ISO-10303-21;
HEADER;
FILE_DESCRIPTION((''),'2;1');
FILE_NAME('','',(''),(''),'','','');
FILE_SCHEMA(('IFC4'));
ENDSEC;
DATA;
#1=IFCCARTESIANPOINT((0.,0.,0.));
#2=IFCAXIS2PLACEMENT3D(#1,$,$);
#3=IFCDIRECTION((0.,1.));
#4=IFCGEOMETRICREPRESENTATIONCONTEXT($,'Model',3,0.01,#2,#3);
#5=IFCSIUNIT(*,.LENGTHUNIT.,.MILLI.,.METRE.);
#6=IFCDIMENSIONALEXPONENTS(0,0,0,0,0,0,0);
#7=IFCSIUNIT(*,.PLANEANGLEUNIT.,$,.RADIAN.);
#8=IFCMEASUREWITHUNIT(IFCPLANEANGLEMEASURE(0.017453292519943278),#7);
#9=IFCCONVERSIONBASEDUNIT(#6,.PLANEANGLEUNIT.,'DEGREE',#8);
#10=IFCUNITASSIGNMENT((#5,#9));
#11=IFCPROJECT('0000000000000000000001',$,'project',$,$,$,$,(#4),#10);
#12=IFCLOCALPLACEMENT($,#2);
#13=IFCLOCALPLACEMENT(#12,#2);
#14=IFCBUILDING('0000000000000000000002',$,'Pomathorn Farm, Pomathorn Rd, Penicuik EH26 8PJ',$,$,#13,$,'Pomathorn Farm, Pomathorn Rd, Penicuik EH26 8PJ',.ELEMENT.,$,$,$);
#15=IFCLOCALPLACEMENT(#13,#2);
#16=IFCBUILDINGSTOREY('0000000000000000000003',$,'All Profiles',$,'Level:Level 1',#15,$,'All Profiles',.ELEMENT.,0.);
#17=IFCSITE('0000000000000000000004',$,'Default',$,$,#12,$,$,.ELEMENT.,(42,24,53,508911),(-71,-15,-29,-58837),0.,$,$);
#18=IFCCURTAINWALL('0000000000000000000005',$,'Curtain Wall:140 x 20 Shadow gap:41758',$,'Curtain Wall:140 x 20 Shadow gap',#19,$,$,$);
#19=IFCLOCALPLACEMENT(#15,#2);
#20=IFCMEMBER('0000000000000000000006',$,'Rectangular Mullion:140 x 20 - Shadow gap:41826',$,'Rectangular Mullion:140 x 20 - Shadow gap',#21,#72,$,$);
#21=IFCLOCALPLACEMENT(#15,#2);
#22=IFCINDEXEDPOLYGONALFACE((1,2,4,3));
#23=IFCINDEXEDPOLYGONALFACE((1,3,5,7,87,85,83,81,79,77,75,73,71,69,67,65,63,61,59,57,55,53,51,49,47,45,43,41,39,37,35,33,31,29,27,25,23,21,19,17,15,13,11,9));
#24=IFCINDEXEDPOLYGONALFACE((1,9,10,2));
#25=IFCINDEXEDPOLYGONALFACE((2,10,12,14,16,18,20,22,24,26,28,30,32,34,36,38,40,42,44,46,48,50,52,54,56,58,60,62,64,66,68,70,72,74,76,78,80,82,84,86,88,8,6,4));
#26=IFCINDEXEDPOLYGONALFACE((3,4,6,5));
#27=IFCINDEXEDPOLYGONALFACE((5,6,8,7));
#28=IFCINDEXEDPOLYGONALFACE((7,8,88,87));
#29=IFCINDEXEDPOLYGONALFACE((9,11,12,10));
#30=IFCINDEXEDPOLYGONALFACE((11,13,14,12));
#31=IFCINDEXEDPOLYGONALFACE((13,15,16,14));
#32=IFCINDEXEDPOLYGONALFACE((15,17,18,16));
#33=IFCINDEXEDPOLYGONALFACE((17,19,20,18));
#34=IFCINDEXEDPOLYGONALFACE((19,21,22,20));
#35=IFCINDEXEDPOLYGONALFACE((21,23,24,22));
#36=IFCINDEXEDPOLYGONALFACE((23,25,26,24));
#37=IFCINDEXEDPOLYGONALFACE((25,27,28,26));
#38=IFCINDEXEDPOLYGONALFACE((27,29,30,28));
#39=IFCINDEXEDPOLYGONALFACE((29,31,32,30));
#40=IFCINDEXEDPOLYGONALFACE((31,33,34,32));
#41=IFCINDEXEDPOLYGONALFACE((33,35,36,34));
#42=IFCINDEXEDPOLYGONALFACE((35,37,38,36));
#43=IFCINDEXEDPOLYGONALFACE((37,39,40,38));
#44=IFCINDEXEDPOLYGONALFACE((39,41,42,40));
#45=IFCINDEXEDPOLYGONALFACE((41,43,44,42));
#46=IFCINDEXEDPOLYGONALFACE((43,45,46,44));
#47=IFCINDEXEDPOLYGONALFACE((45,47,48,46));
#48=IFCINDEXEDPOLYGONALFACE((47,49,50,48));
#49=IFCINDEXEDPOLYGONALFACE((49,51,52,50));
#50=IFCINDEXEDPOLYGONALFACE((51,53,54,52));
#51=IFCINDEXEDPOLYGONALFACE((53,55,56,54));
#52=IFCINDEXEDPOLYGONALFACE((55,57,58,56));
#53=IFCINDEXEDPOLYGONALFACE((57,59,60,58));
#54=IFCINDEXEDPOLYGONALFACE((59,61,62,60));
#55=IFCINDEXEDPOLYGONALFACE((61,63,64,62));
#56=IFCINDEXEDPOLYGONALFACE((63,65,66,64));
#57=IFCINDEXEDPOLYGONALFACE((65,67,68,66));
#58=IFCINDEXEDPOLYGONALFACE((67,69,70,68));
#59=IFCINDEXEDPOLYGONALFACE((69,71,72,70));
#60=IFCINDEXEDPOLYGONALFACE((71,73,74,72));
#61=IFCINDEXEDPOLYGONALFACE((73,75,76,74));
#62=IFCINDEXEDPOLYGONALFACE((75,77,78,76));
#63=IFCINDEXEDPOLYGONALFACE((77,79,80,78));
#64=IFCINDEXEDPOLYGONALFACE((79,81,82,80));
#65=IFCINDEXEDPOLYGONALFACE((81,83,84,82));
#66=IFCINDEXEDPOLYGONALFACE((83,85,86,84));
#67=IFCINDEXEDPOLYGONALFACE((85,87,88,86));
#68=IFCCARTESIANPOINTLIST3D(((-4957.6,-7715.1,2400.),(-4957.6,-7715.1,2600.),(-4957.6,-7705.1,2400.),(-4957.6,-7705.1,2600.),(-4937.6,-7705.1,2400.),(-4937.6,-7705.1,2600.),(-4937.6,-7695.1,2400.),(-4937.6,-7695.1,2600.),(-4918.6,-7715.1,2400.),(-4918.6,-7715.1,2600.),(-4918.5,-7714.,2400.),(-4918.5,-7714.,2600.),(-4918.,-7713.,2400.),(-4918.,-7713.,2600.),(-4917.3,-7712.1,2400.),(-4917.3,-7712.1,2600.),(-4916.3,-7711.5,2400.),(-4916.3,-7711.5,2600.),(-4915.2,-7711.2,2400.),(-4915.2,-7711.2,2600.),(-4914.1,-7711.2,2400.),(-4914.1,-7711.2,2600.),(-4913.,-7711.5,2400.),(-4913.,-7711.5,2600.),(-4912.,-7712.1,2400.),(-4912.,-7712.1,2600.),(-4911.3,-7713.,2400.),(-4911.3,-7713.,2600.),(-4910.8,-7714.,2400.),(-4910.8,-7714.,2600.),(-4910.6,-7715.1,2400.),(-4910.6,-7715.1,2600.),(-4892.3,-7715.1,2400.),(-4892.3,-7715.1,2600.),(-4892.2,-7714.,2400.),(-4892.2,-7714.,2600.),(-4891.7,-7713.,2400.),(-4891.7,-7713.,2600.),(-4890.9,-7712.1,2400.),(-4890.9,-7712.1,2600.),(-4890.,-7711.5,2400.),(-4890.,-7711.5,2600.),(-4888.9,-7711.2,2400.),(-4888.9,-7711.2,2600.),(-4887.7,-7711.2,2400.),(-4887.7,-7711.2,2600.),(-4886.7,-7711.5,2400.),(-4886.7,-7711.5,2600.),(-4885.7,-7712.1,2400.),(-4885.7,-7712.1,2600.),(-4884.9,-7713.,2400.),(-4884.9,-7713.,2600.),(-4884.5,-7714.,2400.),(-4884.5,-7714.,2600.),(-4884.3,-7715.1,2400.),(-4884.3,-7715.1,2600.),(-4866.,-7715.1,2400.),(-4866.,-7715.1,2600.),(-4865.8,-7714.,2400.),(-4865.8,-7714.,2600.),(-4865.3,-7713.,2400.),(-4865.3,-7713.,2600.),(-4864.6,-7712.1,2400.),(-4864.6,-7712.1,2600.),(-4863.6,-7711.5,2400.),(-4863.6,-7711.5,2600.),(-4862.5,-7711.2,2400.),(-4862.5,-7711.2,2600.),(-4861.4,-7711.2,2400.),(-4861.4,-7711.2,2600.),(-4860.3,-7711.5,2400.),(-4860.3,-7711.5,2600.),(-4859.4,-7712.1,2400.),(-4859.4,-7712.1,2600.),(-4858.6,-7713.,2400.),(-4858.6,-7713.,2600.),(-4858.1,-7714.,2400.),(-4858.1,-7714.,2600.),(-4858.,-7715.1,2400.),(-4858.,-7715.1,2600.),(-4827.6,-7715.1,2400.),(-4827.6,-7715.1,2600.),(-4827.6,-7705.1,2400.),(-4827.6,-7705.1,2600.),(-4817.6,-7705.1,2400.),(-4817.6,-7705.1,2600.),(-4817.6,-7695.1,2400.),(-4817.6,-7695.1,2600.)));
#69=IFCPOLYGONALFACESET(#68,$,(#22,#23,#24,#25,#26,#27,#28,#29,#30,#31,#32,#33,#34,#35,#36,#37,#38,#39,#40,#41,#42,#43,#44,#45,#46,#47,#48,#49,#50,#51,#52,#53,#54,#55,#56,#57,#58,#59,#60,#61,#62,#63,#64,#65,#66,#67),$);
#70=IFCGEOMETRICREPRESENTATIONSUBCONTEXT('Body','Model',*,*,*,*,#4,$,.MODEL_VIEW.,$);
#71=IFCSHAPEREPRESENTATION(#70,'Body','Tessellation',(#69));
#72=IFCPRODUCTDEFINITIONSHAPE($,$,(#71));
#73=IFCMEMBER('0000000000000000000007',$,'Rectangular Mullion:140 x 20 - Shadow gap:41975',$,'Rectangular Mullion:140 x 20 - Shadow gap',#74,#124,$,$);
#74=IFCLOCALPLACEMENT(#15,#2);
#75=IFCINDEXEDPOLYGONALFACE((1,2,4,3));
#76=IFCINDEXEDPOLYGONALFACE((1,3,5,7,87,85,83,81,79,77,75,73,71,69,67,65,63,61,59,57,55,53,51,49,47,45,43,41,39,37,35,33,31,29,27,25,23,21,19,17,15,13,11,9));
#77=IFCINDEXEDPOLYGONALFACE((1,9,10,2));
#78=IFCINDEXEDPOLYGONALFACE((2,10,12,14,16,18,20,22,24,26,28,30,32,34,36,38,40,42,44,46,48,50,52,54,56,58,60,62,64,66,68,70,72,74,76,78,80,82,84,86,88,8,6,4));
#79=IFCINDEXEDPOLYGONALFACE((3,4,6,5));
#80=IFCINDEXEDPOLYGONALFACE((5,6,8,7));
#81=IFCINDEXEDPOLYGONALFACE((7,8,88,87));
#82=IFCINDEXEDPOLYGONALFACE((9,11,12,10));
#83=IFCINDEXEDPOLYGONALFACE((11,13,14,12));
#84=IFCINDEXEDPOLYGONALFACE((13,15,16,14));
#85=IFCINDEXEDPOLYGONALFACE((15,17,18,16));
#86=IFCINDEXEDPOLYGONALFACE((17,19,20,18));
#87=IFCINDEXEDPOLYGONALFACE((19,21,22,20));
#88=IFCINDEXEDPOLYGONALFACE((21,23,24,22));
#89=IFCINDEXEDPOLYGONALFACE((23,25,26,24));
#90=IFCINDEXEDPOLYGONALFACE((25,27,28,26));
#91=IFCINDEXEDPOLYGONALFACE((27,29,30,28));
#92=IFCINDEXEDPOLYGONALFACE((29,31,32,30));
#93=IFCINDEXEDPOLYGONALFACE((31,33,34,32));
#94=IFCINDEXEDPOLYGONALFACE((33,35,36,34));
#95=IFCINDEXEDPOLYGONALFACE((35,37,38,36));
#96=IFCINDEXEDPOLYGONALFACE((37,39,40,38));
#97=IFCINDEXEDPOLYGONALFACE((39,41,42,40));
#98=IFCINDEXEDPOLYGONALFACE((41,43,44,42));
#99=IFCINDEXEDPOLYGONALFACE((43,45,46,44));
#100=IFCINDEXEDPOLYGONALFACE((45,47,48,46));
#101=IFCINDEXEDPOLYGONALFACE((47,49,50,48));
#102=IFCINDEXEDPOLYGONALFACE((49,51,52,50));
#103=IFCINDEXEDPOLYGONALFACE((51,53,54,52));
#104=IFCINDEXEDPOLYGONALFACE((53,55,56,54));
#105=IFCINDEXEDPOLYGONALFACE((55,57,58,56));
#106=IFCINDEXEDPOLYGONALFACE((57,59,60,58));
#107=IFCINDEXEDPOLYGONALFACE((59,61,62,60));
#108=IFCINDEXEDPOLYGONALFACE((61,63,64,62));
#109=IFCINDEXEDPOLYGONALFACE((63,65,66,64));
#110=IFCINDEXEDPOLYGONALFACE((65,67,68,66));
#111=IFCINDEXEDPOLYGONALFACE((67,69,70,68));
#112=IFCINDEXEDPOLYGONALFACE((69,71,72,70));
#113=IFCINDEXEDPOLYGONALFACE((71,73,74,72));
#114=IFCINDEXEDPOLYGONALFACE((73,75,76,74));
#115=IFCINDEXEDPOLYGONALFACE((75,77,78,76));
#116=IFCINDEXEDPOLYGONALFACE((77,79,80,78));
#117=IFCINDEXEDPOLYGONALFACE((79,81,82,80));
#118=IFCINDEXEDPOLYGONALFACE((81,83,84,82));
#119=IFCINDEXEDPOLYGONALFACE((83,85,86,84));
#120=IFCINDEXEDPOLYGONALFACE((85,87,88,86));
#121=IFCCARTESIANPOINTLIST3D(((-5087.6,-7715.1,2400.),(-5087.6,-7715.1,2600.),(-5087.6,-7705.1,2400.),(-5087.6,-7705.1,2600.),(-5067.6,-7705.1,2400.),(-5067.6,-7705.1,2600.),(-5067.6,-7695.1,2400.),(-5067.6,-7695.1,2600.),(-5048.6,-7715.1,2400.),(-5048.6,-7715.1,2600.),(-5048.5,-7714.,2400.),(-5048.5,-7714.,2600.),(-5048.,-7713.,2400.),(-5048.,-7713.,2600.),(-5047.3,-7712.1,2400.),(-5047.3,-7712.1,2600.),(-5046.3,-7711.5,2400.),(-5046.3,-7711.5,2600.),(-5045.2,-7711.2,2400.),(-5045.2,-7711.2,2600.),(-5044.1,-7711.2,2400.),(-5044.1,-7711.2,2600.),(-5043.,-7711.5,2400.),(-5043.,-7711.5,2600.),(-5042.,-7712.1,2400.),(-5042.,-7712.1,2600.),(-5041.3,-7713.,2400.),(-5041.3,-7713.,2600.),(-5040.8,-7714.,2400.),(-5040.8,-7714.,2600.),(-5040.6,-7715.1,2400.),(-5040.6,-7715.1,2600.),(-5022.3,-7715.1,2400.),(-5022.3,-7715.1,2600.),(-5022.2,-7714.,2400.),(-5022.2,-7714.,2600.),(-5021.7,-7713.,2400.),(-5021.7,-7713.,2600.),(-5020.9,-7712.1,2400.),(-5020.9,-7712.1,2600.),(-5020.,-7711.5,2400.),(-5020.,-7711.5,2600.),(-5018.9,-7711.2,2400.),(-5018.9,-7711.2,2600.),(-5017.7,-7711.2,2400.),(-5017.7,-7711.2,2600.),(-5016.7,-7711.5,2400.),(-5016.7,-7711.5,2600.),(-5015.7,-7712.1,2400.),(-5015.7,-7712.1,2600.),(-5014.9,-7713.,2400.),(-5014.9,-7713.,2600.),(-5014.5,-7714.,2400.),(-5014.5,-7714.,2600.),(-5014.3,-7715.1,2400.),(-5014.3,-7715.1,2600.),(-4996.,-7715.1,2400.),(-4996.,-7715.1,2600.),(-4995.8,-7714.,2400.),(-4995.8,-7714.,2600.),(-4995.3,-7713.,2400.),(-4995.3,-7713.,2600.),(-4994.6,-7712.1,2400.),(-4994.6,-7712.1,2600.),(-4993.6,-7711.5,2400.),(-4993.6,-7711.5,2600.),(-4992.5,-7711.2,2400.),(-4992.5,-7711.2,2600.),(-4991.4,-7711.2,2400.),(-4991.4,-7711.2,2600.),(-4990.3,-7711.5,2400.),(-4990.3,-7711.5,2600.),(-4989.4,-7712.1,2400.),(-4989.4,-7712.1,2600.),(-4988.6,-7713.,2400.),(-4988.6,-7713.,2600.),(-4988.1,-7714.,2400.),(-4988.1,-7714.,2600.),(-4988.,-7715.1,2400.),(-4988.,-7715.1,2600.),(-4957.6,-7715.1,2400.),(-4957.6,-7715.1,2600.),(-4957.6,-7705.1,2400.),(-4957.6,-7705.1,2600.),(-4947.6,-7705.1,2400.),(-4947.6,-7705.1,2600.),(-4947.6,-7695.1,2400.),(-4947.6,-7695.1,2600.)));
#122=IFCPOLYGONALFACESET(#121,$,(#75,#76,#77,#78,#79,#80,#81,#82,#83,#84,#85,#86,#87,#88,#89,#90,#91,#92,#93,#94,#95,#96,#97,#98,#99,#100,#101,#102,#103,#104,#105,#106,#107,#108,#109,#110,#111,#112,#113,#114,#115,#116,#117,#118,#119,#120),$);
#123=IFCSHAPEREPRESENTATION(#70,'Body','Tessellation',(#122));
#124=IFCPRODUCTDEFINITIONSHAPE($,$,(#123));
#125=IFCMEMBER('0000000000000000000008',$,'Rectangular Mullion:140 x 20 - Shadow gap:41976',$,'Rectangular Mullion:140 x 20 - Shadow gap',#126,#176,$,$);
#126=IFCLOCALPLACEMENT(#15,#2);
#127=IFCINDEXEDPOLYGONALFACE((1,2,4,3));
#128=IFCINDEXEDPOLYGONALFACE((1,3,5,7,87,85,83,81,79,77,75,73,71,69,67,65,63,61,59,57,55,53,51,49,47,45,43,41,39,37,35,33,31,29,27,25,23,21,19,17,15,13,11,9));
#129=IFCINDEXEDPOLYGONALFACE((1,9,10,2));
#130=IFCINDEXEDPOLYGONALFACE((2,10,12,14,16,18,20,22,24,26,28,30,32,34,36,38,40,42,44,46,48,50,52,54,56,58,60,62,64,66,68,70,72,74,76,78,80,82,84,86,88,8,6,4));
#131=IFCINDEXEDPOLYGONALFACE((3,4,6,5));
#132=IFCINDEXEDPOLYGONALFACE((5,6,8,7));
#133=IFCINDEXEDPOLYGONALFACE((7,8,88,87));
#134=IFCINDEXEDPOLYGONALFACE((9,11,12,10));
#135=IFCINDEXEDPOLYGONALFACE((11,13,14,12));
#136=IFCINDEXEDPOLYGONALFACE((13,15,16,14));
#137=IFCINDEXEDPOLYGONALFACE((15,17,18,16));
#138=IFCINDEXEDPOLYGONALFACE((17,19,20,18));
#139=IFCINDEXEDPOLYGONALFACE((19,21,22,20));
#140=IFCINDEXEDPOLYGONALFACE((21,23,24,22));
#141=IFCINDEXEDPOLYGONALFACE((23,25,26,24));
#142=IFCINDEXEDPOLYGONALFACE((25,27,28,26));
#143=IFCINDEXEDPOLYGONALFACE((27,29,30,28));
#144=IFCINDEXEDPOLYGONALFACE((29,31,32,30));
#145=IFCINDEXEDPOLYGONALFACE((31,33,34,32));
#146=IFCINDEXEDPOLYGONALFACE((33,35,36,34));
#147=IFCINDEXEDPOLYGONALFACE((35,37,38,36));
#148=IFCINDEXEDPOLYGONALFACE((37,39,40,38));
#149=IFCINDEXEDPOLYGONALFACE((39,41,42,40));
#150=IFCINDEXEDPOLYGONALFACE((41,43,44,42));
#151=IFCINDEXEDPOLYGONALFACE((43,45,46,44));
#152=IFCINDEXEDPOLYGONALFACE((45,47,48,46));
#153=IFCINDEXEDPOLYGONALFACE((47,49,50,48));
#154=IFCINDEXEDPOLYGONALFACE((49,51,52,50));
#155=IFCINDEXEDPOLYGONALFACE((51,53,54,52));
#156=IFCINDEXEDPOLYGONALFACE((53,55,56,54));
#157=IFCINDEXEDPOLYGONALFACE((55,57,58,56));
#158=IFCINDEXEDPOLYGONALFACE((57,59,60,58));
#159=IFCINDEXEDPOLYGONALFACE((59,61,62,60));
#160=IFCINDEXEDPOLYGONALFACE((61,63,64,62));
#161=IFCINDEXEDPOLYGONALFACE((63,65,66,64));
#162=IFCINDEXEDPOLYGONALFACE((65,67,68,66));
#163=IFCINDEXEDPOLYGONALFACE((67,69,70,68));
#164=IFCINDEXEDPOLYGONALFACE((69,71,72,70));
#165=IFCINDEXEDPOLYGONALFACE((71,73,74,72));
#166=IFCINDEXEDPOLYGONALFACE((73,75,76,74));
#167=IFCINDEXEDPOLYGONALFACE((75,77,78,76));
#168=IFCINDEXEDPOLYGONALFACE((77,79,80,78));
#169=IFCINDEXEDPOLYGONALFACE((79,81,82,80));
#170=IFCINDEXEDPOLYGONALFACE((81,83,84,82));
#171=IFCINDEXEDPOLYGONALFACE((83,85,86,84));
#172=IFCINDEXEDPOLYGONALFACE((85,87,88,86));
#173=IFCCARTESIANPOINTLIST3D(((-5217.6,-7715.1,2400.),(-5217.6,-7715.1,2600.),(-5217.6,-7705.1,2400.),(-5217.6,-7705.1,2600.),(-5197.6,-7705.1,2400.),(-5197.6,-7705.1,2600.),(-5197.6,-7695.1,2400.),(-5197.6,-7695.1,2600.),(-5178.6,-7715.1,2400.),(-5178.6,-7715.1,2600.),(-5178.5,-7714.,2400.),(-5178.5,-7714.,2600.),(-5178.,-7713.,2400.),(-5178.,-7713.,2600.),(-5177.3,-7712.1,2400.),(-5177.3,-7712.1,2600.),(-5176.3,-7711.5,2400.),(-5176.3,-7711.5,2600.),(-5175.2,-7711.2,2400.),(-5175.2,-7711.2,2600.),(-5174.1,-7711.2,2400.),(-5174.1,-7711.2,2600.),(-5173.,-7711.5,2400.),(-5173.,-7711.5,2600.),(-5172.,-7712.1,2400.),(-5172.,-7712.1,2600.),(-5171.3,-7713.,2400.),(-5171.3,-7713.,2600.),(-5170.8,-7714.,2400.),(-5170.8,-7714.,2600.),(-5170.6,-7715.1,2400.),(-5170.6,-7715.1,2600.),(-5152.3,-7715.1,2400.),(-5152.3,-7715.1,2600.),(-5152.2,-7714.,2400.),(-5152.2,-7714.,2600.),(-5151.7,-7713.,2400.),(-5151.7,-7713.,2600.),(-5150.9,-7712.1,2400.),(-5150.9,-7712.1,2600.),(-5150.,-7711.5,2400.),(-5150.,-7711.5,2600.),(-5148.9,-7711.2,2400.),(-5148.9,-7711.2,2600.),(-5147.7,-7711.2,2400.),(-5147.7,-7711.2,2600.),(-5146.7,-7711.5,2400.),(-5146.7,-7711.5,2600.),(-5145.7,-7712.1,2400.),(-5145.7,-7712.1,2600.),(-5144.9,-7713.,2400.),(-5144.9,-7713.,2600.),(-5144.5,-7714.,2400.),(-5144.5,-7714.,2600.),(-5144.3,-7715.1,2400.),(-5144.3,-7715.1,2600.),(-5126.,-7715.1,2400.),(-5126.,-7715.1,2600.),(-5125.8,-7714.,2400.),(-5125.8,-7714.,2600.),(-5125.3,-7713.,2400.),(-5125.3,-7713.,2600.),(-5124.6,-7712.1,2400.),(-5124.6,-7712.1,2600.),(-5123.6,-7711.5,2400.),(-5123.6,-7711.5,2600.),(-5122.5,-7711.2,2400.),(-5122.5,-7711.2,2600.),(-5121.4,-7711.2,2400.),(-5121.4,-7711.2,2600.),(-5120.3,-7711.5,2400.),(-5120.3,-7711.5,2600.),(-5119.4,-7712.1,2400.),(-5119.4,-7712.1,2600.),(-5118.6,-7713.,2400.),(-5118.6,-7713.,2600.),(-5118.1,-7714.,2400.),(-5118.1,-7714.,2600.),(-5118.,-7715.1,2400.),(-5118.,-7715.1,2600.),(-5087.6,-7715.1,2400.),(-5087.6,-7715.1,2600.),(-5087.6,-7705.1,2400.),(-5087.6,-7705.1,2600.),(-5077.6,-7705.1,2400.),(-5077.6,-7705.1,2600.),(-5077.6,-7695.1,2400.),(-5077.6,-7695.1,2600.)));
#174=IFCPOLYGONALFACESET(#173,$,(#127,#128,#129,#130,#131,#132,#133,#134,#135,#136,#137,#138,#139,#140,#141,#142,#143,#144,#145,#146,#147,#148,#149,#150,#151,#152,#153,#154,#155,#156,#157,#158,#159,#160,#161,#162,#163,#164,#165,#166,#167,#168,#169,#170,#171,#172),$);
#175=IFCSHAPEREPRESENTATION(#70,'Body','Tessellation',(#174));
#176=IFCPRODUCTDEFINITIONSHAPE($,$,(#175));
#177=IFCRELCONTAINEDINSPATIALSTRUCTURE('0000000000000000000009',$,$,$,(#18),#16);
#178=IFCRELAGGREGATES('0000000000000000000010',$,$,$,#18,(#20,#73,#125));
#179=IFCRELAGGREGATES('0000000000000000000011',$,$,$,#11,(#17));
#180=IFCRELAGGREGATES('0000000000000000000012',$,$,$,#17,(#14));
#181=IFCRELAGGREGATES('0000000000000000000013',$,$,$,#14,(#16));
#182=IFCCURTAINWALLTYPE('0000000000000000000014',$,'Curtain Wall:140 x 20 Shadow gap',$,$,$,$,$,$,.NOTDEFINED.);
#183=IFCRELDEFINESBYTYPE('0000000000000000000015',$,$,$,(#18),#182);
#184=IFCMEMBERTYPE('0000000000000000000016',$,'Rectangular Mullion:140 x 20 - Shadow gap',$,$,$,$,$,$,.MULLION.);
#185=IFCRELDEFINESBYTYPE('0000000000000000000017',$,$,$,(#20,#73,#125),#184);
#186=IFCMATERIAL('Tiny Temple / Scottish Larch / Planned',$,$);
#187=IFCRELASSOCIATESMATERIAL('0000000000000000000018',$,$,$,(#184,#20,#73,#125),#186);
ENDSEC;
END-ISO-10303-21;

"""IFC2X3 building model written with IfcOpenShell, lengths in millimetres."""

from ifc_helpers import new_model, entity, si_unit, converted_unit, direction, frame, frame_2d, origin, place, context, subcontext, project, spatial, polyline, circle_curve, parameter, trimmed, segment, composite_curve, outline, extrude, source, transform, mapped, material, type_object, type_shapes, element, aggregate, save


model = new_model("IFC2X3")

# Units and contexts
model_context = context("Model", 3, precision=0.01, world=origin(), true_north=direction((0.0, 1.0)))
body_context = subcontext(model_context, "Body", "Model", "MODEL_VIEW")
ifc_project = project(units=[si_unit("LENGTHUNIT", "METRE", prefix="MILLI"), converted_unit("PLANEANGLEUNIT", "DEGREE", entity("IfcPlaneAngleMeasure", 0.017453292519943278), si_unit("PLANEANGLEUNIT", "RADIAN"), dimensions=[0, 0, 0, 0, 0, 0, 0])], contexts=[model_context])

# Site, building, storey
site_placement = place(None, origin())
site = spatial("IfcSite", under=ifc_project, at=site_placement, Name="Default", CompositionType="ELEMENT", RefLatitude=(42, 24, 53, 508911), RefLongitude=(-71, -15, -29, -58837), RefElevation=0.0)
building_placement = place(site_placement, origin())
building = spatial("IfcBuilding", under=site, at=building_placement, Name="Pomathorn Farm, Pomathorn Rd, Penicuik EH26 8PJ", LongName="Pomathorn Farm, Pomathorn Rd, Penicuik EH26 8PJ", CompositionType="ELEMENT")
storey_placement = place(building_placement, origin())
storey = spatial("IfcBuildingStorey", under=building, at=storey_placement, Name="All Profiles", ObjectType="Level:Level 1", LongName="All Profiles", CompositionType="ELEMENT", Elevation=0.0)

# Curtain wall, members
ifc_material = material(Name="Tiny Temple / Scottish Larch / Planned")
curtain_wall_type_1 = type_object("IfcCurtainWallType", Name="Curtain Wall:140 x 20 Shadow gap", PredefinedType="NOTDEFINED")
curtain_wall_1_placement = place(storey_placement, origin())
curtain_wall_1 = element("IfcCurtainWall", 1, at=curtain_wall_1_placement, inside=storey, type_object=curtain_wall_type_1, Name="Curtain Wall:140 x 20 Shadow gap:41758", ObjectType="Curtain Wall:140 x 20 Shadow gap")
member_type_1 = type_object("IfcMemberType", Name="Rectangular Mullion:140 x 20 - Shadow gap", PredefinedType="MULLION", material=ifc_material)
shared_shape_1 = source(origin(), body_context, "Body", "SweptSolid", [
    extrude(outline(composite_curve([segment(polyline([(28.5, -5.7), (58.9, -5.7)]), True, "CONTINUOUS"), segment(polyline([(58.9, -5.7), (58.9, 4.3)]), True, "CONTINUOUS"), segment(polyline([(58.9, 4.3), (68.9, 4.3)]), True, "CONTINUOUS"), segment(polyline([(68.9, 4.3), (68.9, 14.3)]), True, "CONTINUOUS"), segment(polyline([(68.9, 14.3), (-51.1, 14.3)]), True, "CONTINUOUS"), segment(polyline([(-51.1, 14.3), (-51.1, 4.3)]), True, "CONTINUOUS"), segment(polyline([(-51.1, 4.3), (-71.1, 4.3)]), True, "CONTINUOUS"), segment(polyline([(-71.1, 4.3), (-71.1, -5.7)]), True, "CONTINUOUS"), segment(polyline([(-71.1, -5.7), (-32.1, -5.7)]), True, "CONTINUOUS"), segment(trimmed(circle_curve(frame_2d((-28.1, -5.7), x_axis=(1.0, 0.0)), 4.0), [parameter(360.0)], [parameter(180.0)], True, "PARAMETER"), False, "CONTINUOUS"), segment(polyline([(-24.1, -5.7), (-5.8, -5.7)]), True, "CONTINUOUS"), segment(trimmed(circle_curve(frame_2d((-1.8, -5.7), x_axis=(1.0, 0.0)), 4.0), [parameter(360.0)], [parameter(180.0)], True, "PARAMETER"), False, "CONTINUOUS"), segment(polyline([(2.2, -5.7), (20.5, -5.7)]), True, "CONTINUOUS"), segment(trimmed(circle_curve(frame_2d((24.5, -5.7), x_axis=(1.0, 0.0)), 4.0), [parameter(360.0)], [parameter(180.0)], True, "PARAMETER"), False, "CONTINUOUS")], self_intersect=False)), frame((-68.9, -5.7, -200.0), z_axis=(0.0, 0.0, -1.0), x_axis=(1.0, 0.0, 0.0)), (0.0, 0.0, -1.0), 200.0),
])
type_shapes(member_type_1, [shared_shape_1])
member_1_placement = place(curtain_wall_1_placement, frame((-4817.6, -7715.1, 2400.0), z_axis=(0.0, 0.0, -1.0), x_axis=(1.0, 0.0, 0.0)))
member_1 = element("IfcMember", 2, at=member_1_placement, type_object=member_type_1, material=ifc_material, Name="Rectangular Mullion:140 x 20 - Shadow gap:41826", ObjectType="Rectangular Mullion:140 x 20 - Shadow gap", context=body_context, shape_type="MappedRepresentation", body=[
    mapped(shared_shape_1, transform((0.0, 0.0, 0.0), scale=1.0)),
])
member_2_placement = place(curtain_wall_1_placement, frame((-4947.6, -7715.1, 2400.0), z_axis=(0.0, 0.0, -1.0), x_axis=(1.0, 0.0, 0.0)))
member_2 = element("IfcMember", 3, at=member_2_placement, type_object=member_type_1, material=ifc_material, Name="Rectangular Mullion:140 x 20 - Shadow gap:41975", ObjectType="Rectangular Mullion:140 x 20 - Shadow gap", context=body_context, shape_type="MappedRepresentation", body=[
    mapped(shared_shape_1, transform((0.0, 0.0, 0.0), scale=1.0)),
])
member_3_placement = place(curtain_wall_1_placement, frame((-5077.6, -7715.1, 2400.0), z_axis=(0.0, 0.0, -1.0), x_axis=(1.0, 0.0, 0.0)))
member_3 = element("IfcMember", 4, at=member_3_placement, type_object=member_type_1, material=ifc_material, Name="Rectangular Mullion:140 x 20 - Shadow gap:41976", ObjectType="Rectangular Mullion:140 x 20 - Shadow gap", context=body_context, shape_type="MappedRepresentation", body=[
    mapped(shared_shape_1, transform((0.0, 0.0, 0.0), scale=1.0)),
])
aggregate(curtain_wall_1, [member_1, member_2, member_3])

save(model, "model.ifc")
